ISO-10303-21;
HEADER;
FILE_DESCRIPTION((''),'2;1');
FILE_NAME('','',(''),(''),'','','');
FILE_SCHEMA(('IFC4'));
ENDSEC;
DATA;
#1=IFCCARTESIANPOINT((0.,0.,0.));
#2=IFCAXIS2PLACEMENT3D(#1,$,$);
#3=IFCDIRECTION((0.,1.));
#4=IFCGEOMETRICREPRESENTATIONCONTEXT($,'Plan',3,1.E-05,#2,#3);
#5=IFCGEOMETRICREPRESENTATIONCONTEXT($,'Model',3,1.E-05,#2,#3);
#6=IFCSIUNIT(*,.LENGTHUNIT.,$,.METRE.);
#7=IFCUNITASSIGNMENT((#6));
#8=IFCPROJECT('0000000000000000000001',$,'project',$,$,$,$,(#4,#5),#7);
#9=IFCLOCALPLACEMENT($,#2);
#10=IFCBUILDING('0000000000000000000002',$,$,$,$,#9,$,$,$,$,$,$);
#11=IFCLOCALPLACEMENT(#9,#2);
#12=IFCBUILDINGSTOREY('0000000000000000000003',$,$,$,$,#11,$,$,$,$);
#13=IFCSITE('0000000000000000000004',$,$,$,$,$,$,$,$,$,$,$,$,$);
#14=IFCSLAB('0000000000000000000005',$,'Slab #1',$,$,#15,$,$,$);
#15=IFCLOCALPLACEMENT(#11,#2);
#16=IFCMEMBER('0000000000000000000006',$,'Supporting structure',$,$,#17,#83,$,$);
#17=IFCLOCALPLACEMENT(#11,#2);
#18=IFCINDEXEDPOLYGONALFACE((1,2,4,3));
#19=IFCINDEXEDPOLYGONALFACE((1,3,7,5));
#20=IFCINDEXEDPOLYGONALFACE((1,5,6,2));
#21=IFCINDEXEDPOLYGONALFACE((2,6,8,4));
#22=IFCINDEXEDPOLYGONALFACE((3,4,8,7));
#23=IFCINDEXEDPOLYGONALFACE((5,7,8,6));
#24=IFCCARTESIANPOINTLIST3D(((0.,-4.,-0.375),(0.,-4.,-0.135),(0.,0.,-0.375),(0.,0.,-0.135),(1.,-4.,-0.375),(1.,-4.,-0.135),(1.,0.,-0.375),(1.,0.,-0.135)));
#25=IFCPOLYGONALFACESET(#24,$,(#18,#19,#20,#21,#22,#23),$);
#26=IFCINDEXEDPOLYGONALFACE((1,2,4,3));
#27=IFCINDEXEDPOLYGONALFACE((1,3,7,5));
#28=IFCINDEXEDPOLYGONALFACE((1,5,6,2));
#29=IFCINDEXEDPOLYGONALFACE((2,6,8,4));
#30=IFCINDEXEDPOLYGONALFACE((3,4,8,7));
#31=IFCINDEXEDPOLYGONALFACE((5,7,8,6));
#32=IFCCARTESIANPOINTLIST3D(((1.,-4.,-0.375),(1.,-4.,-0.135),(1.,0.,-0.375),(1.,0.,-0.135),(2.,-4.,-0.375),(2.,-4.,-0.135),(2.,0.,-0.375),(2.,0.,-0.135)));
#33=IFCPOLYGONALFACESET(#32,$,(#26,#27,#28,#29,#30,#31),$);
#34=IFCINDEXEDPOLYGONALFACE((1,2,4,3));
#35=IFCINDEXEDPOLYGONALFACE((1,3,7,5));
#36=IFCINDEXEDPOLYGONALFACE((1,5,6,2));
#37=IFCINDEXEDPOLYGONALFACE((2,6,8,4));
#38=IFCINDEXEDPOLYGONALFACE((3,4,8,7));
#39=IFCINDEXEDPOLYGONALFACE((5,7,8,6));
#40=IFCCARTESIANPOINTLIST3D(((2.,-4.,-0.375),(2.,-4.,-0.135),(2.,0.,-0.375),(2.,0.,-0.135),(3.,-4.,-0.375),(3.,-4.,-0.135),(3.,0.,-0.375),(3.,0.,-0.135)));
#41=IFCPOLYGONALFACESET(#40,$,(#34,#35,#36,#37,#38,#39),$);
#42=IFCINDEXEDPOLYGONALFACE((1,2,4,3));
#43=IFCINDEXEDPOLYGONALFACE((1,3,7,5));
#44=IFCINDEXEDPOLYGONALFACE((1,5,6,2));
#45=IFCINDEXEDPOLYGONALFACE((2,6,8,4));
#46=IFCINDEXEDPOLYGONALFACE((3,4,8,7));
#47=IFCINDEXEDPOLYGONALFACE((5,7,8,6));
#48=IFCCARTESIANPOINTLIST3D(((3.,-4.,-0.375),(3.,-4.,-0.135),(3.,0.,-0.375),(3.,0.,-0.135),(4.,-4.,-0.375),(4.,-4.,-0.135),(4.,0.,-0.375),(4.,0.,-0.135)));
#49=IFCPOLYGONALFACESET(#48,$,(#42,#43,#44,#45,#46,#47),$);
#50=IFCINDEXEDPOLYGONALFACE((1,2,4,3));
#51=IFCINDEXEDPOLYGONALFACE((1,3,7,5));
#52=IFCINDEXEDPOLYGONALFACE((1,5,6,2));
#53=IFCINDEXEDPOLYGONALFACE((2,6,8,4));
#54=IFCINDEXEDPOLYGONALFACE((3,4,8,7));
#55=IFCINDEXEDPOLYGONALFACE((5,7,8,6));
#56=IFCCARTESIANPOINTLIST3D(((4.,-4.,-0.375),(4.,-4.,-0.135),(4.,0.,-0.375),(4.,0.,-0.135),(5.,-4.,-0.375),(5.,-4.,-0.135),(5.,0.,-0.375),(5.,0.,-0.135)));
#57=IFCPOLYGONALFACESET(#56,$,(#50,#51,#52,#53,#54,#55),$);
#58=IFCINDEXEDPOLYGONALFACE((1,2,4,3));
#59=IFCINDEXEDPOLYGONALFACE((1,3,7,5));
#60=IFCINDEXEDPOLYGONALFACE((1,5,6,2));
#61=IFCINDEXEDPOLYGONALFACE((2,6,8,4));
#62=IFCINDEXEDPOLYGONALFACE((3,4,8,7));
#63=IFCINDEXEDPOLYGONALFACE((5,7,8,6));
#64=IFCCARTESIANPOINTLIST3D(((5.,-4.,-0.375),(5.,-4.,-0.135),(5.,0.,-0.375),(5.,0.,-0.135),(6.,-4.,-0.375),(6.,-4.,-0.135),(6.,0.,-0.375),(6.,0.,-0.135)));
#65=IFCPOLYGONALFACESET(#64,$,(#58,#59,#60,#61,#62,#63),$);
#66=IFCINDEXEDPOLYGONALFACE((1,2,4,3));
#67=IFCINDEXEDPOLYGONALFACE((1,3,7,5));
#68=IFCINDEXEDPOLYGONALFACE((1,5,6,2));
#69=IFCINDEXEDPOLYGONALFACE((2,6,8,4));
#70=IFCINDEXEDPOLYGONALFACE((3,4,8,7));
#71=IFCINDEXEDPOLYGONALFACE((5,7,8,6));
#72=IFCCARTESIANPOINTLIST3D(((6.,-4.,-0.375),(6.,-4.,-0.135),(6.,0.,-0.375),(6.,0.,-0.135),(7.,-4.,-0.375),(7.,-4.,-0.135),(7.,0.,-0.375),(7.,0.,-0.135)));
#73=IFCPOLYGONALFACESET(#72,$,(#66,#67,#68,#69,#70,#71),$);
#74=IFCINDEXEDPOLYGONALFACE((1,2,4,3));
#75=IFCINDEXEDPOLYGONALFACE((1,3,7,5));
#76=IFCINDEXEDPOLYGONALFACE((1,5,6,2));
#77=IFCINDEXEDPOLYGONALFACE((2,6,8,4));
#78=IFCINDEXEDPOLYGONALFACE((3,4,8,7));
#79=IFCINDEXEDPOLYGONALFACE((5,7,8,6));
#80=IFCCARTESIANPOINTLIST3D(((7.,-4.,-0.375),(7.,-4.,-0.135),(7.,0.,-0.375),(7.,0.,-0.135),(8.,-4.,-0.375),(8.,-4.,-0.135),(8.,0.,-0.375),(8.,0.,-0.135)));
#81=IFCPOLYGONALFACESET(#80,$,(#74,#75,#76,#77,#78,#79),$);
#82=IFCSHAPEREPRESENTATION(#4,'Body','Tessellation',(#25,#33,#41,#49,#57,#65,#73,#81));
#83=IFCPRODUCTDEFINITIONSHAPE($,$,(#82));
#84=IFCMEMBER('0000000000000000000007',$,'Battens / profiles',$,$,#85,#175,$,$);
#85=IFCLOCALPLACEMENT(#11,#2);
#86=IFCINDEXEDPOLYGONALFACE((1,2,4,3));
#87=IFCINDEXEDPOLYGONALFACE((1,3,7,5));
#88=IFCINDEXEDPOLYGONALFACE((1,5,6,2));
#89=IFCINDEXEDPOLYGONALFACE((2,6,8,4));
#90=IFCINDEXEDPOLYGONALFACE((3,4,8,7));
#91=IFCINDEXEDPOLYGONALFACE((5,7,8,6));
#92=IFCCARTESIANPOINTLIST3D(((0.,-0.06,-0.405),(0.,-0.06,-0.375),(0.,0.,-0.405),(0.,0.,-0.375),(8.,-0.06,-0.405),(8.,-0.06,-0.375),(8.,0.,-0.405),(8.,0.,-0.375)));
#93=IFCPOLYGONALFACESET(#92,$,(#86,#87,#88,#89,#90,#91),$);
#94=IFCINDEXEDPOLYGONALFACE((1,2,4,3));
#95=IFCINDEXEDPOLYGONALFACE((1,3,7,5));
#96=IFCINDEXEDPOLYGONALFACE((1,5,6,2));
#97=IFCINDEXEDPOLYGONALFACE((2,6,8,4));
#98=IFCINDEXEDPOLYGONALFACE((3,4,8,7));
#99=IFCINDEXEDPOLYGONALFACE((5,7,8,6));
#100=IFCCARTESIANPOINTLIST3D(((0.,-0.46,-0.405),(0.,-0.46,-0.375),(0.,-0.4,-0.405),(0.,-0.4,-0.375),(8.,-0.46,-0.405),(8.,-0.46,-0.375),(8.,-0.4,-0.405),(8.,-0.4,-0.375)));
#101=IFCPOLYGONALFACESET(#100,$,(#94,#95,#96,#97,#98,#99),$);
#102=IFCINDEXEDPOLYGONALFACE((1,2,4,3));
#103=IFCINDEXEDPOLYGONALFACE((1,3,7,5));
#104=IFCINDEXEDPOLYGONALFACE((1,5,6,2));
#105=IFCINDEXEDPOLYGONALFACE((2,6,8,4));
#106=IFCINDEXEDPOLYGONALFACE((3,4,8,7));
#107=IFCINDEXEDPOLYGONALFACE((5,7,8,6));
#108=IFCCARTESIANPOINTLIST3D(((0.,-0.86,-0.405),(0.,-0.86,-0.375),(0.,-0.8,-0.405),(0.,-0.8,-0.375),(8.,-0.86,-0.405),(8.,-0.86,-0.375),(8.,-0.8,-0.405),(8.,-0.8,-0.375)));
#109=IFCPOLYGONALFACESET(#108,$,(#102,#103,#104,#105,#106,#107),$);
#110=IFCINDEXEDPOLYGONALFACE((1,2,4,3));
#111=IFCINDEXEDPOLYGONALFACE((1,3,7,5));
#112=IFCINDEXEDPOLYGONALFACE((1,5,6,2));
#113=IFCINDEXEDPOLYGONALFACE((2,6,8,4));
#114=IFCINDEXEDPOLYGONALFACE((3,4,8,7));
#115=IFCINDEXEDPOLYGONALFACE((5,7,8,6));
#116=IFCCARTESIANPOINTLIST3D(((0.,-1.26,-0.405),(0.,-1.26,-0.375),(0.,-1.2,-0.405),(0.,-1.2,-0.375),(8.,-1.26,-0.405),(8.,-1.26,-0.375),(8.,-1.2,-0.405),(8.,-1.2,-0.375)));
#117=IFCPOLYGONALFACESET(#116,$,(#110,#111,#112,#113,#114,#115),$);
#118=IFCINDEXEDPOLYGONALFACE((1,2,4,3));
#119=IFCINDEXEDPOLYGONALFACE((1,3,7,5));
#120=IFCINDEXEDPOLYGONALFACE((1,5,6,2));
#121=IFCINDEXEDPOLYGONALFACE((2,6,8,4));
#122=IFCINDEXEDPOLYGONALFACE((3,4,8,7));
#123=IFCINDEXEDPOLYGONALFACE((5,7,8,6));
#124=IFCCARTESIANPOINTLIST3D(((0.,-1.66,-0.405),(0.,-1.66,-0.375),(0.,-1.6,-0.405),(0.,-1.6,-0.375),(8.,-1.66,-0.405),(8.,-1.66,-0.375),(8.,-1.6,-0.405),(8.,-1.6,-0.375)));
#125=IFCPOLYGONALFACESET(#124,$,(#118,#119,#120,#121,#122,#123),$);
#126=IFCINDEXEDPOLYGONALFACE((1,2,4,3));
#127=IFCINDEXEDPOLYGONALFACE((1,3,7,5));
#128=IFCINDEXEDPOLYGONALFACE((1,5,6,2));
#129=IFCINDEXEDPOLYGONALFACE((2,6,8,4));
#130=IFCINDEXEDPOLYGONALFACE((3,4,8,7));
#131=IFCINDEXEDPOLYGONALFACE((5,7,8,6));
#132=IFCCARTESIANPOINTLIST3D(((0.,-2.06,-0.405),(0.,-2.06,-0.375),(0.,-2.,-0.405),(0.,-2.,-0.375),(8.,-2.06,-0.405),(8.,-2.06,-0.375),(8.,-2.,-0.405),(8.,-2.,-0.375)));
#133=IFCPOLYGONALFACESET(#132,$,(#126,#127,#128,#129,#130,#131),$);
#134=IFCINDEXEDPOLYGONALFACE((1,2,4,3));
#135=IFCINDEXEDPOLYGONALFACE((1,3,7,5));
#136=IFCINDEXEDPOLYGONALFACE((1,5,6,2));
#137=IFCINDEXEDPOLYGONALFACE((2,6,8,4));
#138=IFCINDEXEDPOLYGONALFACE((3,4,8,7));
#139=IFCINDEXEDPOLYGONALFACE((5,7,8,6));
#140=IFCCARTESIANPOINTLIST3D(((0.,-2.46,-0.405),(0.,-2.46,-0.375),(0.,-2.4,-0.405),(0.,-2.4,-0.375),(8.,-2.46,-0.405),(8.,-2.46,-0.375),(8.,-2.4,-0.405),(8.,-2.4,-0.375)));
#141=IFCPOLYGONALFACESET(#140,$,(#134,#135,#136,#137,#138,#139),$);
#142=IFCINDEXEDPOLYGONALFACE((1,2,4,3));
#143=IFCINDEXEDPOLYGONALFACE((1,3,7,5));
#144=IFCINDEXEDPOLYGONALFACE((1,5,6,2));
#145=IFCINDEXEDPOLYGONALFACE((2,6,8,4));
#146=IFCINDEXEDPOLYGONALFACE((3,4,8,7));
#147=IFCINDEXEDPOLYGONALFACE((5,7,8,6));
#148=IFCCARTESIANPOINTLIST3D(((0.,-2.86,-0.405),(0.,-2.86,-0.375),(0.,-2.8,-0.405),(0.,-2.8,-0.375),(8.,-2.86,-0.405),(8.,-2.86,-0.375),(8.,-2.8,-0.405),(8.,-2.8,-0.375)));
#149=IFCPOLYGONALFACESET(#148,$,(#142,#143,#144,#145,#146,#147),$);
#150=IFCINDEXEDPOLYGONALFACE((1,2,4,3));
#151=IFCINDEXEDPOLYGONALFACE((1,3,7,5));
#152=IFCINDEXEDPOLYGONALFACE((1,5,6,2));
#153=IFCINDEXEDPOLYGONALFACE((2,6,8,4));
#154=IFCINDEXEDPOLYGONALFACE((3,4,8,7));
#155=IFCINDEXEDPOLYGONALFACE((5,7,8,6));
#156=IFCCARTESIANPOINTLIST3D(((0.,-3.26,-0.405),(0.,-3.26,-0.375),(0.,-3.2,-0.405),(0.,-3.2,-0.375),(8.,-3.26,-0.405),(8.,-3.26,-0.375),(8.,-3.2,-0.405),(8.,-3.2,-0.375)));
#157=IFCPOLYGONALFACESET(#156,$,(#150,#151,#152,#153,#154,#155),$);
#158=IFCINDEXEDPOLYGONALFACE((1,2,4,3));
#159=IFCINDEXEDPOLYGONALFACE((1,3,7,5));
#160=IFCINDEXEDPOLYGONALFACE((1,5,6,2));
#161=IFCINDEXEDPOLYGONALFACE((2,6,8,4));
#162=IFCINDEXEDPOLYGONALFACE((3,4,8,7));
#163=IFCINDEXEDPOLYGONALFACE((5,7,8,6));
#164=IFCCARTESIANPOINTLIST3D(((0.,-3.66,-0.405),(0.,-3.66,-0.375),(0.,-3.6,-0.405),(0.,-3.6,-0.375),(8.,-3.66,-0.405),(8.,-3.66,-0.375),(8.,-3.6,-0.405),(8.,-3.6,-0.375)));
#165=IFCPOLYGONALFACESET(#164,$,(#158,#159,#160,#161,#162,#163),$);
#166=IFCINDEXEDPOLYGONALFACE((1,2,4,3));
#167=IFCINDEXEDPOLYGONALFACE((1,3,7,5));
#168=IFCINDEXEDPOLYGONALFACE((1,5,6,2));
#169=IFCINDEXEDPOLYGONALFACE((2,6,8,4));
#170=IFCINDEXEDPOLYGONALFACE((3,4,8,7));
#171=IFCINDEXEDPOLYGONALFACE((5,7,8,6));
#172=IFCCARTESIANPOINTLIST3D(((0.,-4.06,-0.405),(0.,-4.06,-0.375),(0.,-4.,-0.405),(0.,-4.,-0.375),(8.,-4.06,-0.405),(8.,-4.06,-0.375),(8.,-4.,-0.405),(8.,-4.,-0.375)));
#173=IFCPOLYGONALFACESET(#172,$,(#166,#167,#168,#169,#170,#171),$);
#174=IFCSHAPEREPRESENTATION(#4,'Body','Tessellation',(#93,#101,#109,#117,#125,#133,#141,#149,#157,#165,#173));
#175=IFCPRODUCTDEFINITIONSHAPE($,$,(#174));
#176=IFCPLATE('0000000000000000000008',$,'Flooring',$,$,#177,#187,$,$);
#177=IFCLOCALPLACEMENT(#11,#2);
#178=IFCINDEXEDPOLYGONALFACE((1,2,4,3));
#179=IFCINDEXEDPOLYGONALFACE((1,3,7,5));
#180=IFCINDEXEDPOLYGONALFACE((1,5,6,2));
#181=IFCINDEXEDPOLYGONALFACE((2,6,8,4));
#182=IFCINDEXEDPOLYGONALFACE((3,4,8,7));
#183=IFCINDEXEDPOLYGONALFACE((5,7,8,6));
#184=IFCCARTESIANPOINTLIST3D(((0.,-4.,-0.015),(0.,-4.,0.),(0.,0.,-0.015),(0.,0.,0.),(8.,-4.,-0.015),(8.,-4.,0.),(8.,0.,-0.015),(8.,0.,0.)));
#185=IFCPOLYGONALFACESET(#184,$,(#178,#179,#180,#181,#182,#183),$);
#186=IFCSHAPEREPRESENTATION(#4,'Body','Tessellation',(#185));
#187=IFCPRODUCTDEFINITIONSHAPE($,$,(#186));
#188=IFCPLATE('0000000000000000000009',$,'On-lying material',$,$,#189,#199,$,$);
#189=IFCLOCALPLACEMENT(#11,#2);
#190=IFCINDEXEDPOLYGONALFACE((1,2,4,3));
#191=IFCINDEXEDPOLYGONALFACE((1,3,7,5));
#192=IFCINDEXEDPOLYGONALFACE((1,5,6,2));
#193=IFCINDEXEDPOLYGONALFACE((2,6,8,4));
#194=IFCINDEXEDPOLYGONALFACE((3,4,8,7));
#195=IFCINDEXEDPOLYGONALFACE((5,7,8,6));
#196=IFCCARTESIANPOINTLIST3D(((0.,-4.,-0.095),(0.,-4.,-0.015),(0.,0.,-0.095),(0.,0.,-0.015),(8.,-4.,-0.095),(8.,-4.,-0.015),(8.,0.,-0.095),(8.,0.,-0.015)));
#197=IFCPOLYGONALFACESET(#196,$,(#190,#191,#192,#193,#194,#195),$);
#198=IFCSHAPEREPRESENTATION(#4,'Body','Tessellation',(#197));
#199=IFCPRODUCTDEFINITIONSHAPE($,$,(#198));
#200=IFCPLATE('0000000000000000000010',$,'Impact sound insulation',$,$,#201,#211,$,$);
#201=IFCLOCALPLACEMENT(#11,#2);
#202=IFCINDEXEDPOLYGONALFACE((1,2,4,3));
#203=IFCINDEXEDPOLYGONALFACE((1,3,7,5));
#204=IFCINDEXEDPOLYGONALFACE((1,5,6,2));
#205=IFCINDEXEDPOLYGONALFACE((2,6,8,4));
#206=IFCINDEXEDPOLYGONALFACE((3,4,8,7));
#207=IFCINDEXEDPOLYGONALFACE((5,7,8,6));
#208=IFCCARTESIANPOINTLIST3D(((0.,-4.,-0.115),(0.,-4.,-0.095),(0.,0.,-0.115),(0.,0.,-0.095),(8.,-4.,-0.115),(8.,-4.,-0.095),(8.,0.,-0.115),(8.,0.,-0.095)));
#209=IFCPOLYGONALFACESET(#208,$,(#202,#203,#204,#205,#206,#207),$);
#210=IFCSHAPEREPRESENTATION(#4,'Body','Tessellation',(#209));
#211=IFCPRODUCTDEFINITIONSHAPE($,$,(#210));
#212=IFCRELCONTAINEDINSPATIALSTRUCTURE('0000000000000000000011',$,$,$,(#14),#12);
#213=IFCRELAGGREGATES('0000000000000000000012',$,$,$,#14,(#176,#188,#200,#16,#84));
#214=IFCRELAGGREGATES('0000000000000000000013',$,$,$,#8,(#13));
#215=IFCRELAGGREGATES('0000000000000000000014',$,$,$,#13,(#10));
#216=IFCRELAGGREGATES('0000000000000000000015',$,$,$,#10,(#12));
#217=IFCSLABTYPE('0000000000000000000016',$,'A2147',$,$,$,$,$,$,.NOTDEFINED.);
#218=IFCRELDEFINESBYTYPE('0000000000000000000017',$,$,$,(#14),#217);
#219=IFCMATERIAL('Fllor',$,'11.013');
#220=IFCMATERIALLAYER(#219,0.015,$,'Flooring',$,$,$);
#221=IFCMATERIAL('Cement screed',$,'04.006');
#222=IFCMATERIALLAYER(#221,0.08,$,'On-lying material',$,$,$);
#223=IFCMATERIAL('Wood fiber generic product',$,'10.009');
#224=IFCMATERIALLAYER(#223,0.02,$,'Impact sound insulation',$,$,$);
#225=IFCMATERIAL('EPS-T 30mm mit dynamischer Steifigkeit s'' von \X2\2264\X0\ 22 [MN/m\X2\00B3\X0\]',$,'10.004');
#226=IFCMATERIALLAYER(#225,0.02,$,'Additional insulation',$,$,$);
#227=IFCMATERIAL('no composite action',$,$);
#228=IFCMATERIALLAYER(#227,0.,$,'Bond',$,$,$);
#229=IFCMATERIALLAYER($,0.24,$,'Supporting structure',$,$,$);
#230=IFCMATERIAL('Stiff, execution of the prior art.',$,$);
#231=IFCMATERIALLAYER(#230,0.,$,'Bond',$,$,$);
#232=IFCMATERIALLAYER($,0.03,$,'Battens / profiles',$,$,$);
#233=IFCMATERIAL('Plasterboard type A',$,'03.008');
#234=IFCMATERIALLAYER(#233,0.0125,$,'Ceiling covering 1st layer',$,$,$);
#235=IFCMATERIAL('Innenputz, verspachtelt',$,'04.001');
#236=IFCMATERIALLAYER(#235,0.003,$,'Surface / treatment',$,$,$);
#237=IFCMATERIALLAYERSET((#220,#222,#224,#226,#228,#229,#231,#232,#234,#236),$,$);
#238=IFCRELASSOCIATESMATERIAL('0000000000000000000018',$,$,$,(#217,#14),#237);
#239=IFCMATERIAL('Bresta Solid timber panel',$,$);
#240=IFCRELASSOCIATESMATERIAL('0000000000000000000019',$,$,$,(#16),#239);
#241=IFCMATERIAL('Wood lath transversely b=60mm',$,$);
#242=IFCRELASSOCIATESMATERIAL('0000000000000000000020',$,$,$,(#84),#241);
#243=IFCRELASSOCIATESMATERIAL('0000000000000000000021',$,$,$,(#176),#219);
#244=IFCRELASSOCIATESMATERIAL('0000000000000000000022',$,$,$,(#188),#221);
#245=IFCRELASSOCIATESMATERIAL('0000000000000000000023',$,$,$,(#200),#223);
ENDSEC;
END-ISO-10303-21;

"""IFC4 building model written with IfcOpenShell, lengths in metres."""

from ifc_helpers import new_model, si_unit, direction, frame, frame_2d, origin, origin_with_axes, place, context, project, spatial, rectangle, extrude, material, layer, layer_set, type_object, element, aggregate, save


model = new_model("IFC4")

# Units and contexts
plan_context = context("Plan", 3, precision=1e-05, world=origin(), true_north=direction((0.0, 1.0)))
model_context = context("Model", 3, precision=1e-05, world=origin(), true_north=direction((0.0, 1.0)))
ifc_project = project(units=[si_unit("LENGTHUNIT", "METRE")], contexts=[plan_context, model_context])

# Site, building, storey
site = spatial("IfcSite", under=ifc_project)
building_placement = place(None, origin())
building = spatial("IfcBuilding", under=site, at=building_placement)
storey_placement = place(building_placement, origin())
storey = spatial("IfcBuildingStorey", under=building, at=storey_placement)

# Slab, members, plates
ifc_material_1 = material(Name="Fllor", Category="11.013")
ifc_layer_1 = layer(ifc_material_1, 0.015, Name="Flooring")
ifc_material_2 = material(Name="Cement screed", Category="04.006")
ifc_layer_2 = layer(ifc_material_2, 0.08, Name="On-lying material")
ifc_material_3 = material(Name="Wood fiber generic product", Category="10.009")
ifc_layer_3 = layer(ifc_material_3, 0.02, Name="Impact sound insulation")
ifc_material_4 = material(Name="EPS-T 30mm mit dynamischer Steifigkeit s' von ≤ 22 [MN/m³]", Category="10.004")
ifc_layer_4 = layer(ifc_material_4, 0.02, Name="Additional insulation")
ifc_material_5 = material(Name="no composite action")
ifc_layer_5 = layer(ifc_material_5, 0.0, Name="Bond")
ifc_layer_6 = layer(None, 0.24, Name="Supporting structure")
ifc_material_6 = material(Name="Stiff, execution of the prior art.")
ifc_layer_7 = layer(ifc_material_6, 0.0, Name="Bond")
ifc_layer_8 = layer(None, 0.03, Name="Battens / profiles")
ifc_material_7 = material(Name="Plasterboard type A", Category="03.008")
ifc_layer_9 = layer(ifc_material_7, 0.0125, Name="Ceiling covering 1st layer")
ifc_material_8 = material(Name="Innenputz, verspachtelt", Category="04.001")
ifc_layer_10 = layer(ifc_material_8, 0.003, Name="Surface / treatment")
ifc_layer_set = layer_set([ifc_layer_1, ifc_layer_2, ifc_layer_3, ifc_layer_4, ifc_layer_5, ifc_layer_6, ifc_layer_7, ifc_layer_8, ifc_layer_9, ifc_layer_10])
slab_type = type_object("IfcSlabType", Name="A2147", PredefinedType="NOTDEFINED", material=ifc_layer_set)
slab_placement = place(None, frame((0.0, 0.0, 0.0), z_axis=(0.0, 0.0, -1.0), x_axis=(1.0, 0.0, 0.0)))
slab = element("IfcSlab", 1, at=slab_placement, inside=storey, type_object=slab_type, material=ifc_layer_set, Name="Slab #1")
ifc_material_9 = material(Name="Bresta Solid timber panel")
member_1_placement = place(slab_placement, origin())
member_1 = element("IfcMember", 2, at=member_1_placement, material=ifc_material_9, Name="Supporting structure", context=plan_context, shape_type="SweptSolid", body=[
    extrude(rectangle(XDim=1.0, YDim=0.24, at=frame_2d((0.5, 0.12), x_axis=(1.0, 0.0))), frame((0.0, 4.0, 0.135), z_axis=(0.0, -1.0, 0.0), x_axis=(1.0, 0.0, 0.0)), (0.0, 0.0, 1.0), 4.0),
    extrude(rectangle(XDim=1.0, YDim=0.24, at=frame_2d((0.5, 0.12), x_axis=(1.0, 0.0))), frame((1.0, 4.0, 0.135), z_axis=(0.0, -1.0, 0.0), x_axis=(1.0, 0.0, 0.0)), (0.0, 0.0, 1.0), 4.0),
    extrude(rectangle(XDim=1.0, YDim=0.24, at=frame_2d((0.5, 0.12), x_axis=(1.0, 0.0))), frame((2.0, 4.0, 0.135), z_axis=(0.0, -1.0, 0.0), x_axis=(1.0, 0.0, 0.0)), (0.0, 0.0, 1.0), 4.0),
    extrude(rectangle(XDim=1.0, YDim=0.24, at=frame_2d((0.5, 0.12), x_axis=(1.0, 0.0))), frame((3.0, 4.0, 0.135), z_axis=(0.0, -1.0, 0.0), x_axis=(1.0, 0.0, 0.0)), (0.0, 0.0, 1.0), 4.0),
    extrude(rectangle(XDim=1.0, YDim=0.24, at=frame_2d((0.5, 0.12), x_axis=(1.0, 0.0))), frame((4.0, 4.0, 0.135), z_axis=(0.0, -1.0, 0.0), x_axis=(1.0, 0.0, 0.0)), (0.0, 0.0, 1.0), 4.0),
    extrude(rectangle(XDim=1.0, YDim=0.24, at=frame_2d((0.5, 0.12), x_axis=(1.0, 0.0))), frame((5.0, 4.0, 0.135), z_axis=(0.0, -1.0, 0.0), x_axis=(1.0, 0.0, 0.0)), (0.0, 0.0, 1.0), 4.0),
    extrude(rectangle(XDim=1.0, YDim=0.24, at=frame_2d((0.5, 0.12), x_axis=(1.0, 0.0))), frame((6.0, 4.0, 0.135), z_axis=(0.0, -1.0, 0.0), x_axis=(1.0, 0.0, 0.0)), (0.0, 0.0, 1.0), 4.0),
    extrude(rectangle(XDim=1.0, YDim=0.24, at=frame_2d((0.5, 0.12), x_axis=(1.0, 0.0))), frame((7.0, 4.0, 0.135), z_axis=(0.0, -1.0, 0.0), x_axis=(1.0, 0.0, 0.0)), (0.0, 0.0, 1.0), 4.0),
])
ifc_material_10 = material(Name="Wood lath transversely b=60mm")
member_2_placement = place(slab_placement, origin())
member_2 = element("IfcMember", 3, at=member_2_placement, material=ifc_material_10, Name="Battens / profiles", context=plan_context, shape_type="SweptSolid", body=[
    extrude(rectangle(XDim=0.06, YDim=0.03, at=frame_2d((0.03, 0.015), x_axis=(1.0, 0.0))), frame((0.0, 0.0, 0.375), z_axis=(1.0, 0.0, 0.0), x_axis=(0.0, 1.0, 0.0)), (0.0, 0.0, 1.0), 8.0),
    extrude(rectangle(XDim=0.06, YDim=0.03, at=frame_2d((0.03, 0.015), x_axis=(1.0, 0.0))), frame((0.0, 0.4, 0.375), z_axis=(1.0, 0.0, 0.0), x_axis=(0.0, 1.0, 0.0)), (0.0, 0.0, 1.0), 8.0),
    extrude(rectangle(XDim=0.06, YDim=0.03, at=frame_2d((0.03, 0.015), x_axis=(1.0, 0.0))), frame((0.0, 0.8, 0.375), z_axis=(1.0, 0.0, 0.0), x_axis=(0.0, 1.0, 0.0)), (0.0, 0.0, 1.0), 8.0),
    extrude(rectangle(XDim=0.06, YDim=0.03, at=frame_2d((0.03, 0.015), x_axis=(1.0, 0.0))), frame((0.0, 1.2, 0.375), z_axis=(1.0, 0.0, 0.0), x_axis=(0.0, 1.0, 0.0)), (0.0, 0.0, 1.0), 8.0),
    extrude(rectangle(XDim=0.06, YDim=0.03, at=frame_2d((0.03, 0.015), x_axis=(1.0, 0.0))), frame((0.0, 1.6, 0.375), z_axis=(1.0, 0.0, 0.0), x_axis=(0.0, 1.0, 0.0)), (0.0, 0.0, 1.0), 8.0),
    extrude(rectangle(XDim=0.06, YDim=0.03, at=frame_2d((0.03, 0.015), x_axis=(1.0, 0.0))), frame((0.0, 2.0, 0.375), z_axis=(1.0, 0.0, 0.0), x_axis=(0.0, 1.0, 0.0)), (0.0, 0.0, 1.0), 8.0),
    extrude(rectangle(XDim=0.06, YDim=0.03, at=frame_2d((0.03, 0.015), x_axis=(1.0, 0.0))), frame((0.0, 2.4, 0.375), z_axis=(1.0, 0.0, 0.0), x_axis=(0.0, 1.0, 0.0)), (0.0, 0.0, 1.0), 8.0),
    extrude(rectangle(XDim=0.06, YDim=0.03, at=frame_2d((0.03, 0.015), x_axis=(1.0, 0.0))), frame((0.0, 2.8, 0.375), z_axis=(1.0, 0.0, 0.0), x_axis=(0.0, 1.0, 0.0)), (0.0, 0.0, 1.0), 8.0),
    extrude(rectangle(XDim=0.06, YDim=0.03, at=frame_2d((0.03, 0.015), x_axis=(1.0, 0.0))), frame((0.0, 3.2, 0.375), z_axis=(1.0, 0.0, 0.0), x_axis=(0.0, 1.0, 0.0)), (0.0, 0.0, 1.0), 8.0),
    extrude(rectangle(XDim=0.06, YDim=0.03, at=frame_2d((0.03, 0.015), x_axis=(1.0, 0.0))), frame((0.0, 3.6, 0.375), z_axis=(1.0, 0.0, 0.0), x_axis=(0.0, 1.0, 0.0)), (0.0, 0.0, 1.0), 8.0),
    extrude(rectangle(XDim=0.06, YDim=0.03, at=frame_2d((0.03, 0.015), x_axis=(1.0, 0.0))), frame((0.0, 4.0, 0.375), z_axis=(1.0, 0.0, 0.0), x_axis=(0.0, 1.0, 0.0)), (0.0, 0.0, 1.0), 8.0),
])
plate_1_placement = place(slab_placement, origin())
plate_1 = element("IfcPlate", 4, at=plate_1_placement, material=ifc_material_1, Name="Flooring", context=plan_context, shape_type="SweptSolid", body=[
    extrude(rectangle(XDim=8.0, YDim=4.0, at=frame_2d((4.0, 2.0), x_axis=(1.0, 0.0))), origin_with_axes(), (0.0, 0.0, 1.0), 0.015),
])
plate_2_placement = place(slab_placement, origin())
plate_2 = element("IfcPlate", 5, at=plate_2_placement, material=ifc_material_2, Name="On-lying material", context=plan_context, shape_type="SweptSolid", body=[
    extrude(rectangle(XDim=8.0, YDim=4.0, at=frame_2d((4.0, 2.0), x_axis=(1.0, 0.0))), frame((0.0, 0.0, 0.015), z_axis=(0.0, 0.0, 1.0), x_axis=(1.0, 0.0, 0.0)), (0.0, 0.0, 1.0), 0.08),
])
plate_3_placement = place(slab_placement, origin())
plate_3 = element("IfcPlate", 6, at=plate_3_placement, material=ifc_material_3, Name="Impact sound insulation", context=plan_context, shape_type="SweptSolid", body=[
    extrude(rectangle(XDim=8.0, YDim=4.0, at=frame_2d((4.0, 2.0), x_axis=(1.0, 0.0))), frame((0.0, 0.0, 0.095), z_axis=(0.0, 0.0, 1.0), x_axis=(1.0, 0.0, 0.0)), (0.0, 0.0, 1.0), 0.02),
])
aggregate(slab, [plate_1, plate_2, plate_3, member_1, member_2])

save(model, "model.ifc")
